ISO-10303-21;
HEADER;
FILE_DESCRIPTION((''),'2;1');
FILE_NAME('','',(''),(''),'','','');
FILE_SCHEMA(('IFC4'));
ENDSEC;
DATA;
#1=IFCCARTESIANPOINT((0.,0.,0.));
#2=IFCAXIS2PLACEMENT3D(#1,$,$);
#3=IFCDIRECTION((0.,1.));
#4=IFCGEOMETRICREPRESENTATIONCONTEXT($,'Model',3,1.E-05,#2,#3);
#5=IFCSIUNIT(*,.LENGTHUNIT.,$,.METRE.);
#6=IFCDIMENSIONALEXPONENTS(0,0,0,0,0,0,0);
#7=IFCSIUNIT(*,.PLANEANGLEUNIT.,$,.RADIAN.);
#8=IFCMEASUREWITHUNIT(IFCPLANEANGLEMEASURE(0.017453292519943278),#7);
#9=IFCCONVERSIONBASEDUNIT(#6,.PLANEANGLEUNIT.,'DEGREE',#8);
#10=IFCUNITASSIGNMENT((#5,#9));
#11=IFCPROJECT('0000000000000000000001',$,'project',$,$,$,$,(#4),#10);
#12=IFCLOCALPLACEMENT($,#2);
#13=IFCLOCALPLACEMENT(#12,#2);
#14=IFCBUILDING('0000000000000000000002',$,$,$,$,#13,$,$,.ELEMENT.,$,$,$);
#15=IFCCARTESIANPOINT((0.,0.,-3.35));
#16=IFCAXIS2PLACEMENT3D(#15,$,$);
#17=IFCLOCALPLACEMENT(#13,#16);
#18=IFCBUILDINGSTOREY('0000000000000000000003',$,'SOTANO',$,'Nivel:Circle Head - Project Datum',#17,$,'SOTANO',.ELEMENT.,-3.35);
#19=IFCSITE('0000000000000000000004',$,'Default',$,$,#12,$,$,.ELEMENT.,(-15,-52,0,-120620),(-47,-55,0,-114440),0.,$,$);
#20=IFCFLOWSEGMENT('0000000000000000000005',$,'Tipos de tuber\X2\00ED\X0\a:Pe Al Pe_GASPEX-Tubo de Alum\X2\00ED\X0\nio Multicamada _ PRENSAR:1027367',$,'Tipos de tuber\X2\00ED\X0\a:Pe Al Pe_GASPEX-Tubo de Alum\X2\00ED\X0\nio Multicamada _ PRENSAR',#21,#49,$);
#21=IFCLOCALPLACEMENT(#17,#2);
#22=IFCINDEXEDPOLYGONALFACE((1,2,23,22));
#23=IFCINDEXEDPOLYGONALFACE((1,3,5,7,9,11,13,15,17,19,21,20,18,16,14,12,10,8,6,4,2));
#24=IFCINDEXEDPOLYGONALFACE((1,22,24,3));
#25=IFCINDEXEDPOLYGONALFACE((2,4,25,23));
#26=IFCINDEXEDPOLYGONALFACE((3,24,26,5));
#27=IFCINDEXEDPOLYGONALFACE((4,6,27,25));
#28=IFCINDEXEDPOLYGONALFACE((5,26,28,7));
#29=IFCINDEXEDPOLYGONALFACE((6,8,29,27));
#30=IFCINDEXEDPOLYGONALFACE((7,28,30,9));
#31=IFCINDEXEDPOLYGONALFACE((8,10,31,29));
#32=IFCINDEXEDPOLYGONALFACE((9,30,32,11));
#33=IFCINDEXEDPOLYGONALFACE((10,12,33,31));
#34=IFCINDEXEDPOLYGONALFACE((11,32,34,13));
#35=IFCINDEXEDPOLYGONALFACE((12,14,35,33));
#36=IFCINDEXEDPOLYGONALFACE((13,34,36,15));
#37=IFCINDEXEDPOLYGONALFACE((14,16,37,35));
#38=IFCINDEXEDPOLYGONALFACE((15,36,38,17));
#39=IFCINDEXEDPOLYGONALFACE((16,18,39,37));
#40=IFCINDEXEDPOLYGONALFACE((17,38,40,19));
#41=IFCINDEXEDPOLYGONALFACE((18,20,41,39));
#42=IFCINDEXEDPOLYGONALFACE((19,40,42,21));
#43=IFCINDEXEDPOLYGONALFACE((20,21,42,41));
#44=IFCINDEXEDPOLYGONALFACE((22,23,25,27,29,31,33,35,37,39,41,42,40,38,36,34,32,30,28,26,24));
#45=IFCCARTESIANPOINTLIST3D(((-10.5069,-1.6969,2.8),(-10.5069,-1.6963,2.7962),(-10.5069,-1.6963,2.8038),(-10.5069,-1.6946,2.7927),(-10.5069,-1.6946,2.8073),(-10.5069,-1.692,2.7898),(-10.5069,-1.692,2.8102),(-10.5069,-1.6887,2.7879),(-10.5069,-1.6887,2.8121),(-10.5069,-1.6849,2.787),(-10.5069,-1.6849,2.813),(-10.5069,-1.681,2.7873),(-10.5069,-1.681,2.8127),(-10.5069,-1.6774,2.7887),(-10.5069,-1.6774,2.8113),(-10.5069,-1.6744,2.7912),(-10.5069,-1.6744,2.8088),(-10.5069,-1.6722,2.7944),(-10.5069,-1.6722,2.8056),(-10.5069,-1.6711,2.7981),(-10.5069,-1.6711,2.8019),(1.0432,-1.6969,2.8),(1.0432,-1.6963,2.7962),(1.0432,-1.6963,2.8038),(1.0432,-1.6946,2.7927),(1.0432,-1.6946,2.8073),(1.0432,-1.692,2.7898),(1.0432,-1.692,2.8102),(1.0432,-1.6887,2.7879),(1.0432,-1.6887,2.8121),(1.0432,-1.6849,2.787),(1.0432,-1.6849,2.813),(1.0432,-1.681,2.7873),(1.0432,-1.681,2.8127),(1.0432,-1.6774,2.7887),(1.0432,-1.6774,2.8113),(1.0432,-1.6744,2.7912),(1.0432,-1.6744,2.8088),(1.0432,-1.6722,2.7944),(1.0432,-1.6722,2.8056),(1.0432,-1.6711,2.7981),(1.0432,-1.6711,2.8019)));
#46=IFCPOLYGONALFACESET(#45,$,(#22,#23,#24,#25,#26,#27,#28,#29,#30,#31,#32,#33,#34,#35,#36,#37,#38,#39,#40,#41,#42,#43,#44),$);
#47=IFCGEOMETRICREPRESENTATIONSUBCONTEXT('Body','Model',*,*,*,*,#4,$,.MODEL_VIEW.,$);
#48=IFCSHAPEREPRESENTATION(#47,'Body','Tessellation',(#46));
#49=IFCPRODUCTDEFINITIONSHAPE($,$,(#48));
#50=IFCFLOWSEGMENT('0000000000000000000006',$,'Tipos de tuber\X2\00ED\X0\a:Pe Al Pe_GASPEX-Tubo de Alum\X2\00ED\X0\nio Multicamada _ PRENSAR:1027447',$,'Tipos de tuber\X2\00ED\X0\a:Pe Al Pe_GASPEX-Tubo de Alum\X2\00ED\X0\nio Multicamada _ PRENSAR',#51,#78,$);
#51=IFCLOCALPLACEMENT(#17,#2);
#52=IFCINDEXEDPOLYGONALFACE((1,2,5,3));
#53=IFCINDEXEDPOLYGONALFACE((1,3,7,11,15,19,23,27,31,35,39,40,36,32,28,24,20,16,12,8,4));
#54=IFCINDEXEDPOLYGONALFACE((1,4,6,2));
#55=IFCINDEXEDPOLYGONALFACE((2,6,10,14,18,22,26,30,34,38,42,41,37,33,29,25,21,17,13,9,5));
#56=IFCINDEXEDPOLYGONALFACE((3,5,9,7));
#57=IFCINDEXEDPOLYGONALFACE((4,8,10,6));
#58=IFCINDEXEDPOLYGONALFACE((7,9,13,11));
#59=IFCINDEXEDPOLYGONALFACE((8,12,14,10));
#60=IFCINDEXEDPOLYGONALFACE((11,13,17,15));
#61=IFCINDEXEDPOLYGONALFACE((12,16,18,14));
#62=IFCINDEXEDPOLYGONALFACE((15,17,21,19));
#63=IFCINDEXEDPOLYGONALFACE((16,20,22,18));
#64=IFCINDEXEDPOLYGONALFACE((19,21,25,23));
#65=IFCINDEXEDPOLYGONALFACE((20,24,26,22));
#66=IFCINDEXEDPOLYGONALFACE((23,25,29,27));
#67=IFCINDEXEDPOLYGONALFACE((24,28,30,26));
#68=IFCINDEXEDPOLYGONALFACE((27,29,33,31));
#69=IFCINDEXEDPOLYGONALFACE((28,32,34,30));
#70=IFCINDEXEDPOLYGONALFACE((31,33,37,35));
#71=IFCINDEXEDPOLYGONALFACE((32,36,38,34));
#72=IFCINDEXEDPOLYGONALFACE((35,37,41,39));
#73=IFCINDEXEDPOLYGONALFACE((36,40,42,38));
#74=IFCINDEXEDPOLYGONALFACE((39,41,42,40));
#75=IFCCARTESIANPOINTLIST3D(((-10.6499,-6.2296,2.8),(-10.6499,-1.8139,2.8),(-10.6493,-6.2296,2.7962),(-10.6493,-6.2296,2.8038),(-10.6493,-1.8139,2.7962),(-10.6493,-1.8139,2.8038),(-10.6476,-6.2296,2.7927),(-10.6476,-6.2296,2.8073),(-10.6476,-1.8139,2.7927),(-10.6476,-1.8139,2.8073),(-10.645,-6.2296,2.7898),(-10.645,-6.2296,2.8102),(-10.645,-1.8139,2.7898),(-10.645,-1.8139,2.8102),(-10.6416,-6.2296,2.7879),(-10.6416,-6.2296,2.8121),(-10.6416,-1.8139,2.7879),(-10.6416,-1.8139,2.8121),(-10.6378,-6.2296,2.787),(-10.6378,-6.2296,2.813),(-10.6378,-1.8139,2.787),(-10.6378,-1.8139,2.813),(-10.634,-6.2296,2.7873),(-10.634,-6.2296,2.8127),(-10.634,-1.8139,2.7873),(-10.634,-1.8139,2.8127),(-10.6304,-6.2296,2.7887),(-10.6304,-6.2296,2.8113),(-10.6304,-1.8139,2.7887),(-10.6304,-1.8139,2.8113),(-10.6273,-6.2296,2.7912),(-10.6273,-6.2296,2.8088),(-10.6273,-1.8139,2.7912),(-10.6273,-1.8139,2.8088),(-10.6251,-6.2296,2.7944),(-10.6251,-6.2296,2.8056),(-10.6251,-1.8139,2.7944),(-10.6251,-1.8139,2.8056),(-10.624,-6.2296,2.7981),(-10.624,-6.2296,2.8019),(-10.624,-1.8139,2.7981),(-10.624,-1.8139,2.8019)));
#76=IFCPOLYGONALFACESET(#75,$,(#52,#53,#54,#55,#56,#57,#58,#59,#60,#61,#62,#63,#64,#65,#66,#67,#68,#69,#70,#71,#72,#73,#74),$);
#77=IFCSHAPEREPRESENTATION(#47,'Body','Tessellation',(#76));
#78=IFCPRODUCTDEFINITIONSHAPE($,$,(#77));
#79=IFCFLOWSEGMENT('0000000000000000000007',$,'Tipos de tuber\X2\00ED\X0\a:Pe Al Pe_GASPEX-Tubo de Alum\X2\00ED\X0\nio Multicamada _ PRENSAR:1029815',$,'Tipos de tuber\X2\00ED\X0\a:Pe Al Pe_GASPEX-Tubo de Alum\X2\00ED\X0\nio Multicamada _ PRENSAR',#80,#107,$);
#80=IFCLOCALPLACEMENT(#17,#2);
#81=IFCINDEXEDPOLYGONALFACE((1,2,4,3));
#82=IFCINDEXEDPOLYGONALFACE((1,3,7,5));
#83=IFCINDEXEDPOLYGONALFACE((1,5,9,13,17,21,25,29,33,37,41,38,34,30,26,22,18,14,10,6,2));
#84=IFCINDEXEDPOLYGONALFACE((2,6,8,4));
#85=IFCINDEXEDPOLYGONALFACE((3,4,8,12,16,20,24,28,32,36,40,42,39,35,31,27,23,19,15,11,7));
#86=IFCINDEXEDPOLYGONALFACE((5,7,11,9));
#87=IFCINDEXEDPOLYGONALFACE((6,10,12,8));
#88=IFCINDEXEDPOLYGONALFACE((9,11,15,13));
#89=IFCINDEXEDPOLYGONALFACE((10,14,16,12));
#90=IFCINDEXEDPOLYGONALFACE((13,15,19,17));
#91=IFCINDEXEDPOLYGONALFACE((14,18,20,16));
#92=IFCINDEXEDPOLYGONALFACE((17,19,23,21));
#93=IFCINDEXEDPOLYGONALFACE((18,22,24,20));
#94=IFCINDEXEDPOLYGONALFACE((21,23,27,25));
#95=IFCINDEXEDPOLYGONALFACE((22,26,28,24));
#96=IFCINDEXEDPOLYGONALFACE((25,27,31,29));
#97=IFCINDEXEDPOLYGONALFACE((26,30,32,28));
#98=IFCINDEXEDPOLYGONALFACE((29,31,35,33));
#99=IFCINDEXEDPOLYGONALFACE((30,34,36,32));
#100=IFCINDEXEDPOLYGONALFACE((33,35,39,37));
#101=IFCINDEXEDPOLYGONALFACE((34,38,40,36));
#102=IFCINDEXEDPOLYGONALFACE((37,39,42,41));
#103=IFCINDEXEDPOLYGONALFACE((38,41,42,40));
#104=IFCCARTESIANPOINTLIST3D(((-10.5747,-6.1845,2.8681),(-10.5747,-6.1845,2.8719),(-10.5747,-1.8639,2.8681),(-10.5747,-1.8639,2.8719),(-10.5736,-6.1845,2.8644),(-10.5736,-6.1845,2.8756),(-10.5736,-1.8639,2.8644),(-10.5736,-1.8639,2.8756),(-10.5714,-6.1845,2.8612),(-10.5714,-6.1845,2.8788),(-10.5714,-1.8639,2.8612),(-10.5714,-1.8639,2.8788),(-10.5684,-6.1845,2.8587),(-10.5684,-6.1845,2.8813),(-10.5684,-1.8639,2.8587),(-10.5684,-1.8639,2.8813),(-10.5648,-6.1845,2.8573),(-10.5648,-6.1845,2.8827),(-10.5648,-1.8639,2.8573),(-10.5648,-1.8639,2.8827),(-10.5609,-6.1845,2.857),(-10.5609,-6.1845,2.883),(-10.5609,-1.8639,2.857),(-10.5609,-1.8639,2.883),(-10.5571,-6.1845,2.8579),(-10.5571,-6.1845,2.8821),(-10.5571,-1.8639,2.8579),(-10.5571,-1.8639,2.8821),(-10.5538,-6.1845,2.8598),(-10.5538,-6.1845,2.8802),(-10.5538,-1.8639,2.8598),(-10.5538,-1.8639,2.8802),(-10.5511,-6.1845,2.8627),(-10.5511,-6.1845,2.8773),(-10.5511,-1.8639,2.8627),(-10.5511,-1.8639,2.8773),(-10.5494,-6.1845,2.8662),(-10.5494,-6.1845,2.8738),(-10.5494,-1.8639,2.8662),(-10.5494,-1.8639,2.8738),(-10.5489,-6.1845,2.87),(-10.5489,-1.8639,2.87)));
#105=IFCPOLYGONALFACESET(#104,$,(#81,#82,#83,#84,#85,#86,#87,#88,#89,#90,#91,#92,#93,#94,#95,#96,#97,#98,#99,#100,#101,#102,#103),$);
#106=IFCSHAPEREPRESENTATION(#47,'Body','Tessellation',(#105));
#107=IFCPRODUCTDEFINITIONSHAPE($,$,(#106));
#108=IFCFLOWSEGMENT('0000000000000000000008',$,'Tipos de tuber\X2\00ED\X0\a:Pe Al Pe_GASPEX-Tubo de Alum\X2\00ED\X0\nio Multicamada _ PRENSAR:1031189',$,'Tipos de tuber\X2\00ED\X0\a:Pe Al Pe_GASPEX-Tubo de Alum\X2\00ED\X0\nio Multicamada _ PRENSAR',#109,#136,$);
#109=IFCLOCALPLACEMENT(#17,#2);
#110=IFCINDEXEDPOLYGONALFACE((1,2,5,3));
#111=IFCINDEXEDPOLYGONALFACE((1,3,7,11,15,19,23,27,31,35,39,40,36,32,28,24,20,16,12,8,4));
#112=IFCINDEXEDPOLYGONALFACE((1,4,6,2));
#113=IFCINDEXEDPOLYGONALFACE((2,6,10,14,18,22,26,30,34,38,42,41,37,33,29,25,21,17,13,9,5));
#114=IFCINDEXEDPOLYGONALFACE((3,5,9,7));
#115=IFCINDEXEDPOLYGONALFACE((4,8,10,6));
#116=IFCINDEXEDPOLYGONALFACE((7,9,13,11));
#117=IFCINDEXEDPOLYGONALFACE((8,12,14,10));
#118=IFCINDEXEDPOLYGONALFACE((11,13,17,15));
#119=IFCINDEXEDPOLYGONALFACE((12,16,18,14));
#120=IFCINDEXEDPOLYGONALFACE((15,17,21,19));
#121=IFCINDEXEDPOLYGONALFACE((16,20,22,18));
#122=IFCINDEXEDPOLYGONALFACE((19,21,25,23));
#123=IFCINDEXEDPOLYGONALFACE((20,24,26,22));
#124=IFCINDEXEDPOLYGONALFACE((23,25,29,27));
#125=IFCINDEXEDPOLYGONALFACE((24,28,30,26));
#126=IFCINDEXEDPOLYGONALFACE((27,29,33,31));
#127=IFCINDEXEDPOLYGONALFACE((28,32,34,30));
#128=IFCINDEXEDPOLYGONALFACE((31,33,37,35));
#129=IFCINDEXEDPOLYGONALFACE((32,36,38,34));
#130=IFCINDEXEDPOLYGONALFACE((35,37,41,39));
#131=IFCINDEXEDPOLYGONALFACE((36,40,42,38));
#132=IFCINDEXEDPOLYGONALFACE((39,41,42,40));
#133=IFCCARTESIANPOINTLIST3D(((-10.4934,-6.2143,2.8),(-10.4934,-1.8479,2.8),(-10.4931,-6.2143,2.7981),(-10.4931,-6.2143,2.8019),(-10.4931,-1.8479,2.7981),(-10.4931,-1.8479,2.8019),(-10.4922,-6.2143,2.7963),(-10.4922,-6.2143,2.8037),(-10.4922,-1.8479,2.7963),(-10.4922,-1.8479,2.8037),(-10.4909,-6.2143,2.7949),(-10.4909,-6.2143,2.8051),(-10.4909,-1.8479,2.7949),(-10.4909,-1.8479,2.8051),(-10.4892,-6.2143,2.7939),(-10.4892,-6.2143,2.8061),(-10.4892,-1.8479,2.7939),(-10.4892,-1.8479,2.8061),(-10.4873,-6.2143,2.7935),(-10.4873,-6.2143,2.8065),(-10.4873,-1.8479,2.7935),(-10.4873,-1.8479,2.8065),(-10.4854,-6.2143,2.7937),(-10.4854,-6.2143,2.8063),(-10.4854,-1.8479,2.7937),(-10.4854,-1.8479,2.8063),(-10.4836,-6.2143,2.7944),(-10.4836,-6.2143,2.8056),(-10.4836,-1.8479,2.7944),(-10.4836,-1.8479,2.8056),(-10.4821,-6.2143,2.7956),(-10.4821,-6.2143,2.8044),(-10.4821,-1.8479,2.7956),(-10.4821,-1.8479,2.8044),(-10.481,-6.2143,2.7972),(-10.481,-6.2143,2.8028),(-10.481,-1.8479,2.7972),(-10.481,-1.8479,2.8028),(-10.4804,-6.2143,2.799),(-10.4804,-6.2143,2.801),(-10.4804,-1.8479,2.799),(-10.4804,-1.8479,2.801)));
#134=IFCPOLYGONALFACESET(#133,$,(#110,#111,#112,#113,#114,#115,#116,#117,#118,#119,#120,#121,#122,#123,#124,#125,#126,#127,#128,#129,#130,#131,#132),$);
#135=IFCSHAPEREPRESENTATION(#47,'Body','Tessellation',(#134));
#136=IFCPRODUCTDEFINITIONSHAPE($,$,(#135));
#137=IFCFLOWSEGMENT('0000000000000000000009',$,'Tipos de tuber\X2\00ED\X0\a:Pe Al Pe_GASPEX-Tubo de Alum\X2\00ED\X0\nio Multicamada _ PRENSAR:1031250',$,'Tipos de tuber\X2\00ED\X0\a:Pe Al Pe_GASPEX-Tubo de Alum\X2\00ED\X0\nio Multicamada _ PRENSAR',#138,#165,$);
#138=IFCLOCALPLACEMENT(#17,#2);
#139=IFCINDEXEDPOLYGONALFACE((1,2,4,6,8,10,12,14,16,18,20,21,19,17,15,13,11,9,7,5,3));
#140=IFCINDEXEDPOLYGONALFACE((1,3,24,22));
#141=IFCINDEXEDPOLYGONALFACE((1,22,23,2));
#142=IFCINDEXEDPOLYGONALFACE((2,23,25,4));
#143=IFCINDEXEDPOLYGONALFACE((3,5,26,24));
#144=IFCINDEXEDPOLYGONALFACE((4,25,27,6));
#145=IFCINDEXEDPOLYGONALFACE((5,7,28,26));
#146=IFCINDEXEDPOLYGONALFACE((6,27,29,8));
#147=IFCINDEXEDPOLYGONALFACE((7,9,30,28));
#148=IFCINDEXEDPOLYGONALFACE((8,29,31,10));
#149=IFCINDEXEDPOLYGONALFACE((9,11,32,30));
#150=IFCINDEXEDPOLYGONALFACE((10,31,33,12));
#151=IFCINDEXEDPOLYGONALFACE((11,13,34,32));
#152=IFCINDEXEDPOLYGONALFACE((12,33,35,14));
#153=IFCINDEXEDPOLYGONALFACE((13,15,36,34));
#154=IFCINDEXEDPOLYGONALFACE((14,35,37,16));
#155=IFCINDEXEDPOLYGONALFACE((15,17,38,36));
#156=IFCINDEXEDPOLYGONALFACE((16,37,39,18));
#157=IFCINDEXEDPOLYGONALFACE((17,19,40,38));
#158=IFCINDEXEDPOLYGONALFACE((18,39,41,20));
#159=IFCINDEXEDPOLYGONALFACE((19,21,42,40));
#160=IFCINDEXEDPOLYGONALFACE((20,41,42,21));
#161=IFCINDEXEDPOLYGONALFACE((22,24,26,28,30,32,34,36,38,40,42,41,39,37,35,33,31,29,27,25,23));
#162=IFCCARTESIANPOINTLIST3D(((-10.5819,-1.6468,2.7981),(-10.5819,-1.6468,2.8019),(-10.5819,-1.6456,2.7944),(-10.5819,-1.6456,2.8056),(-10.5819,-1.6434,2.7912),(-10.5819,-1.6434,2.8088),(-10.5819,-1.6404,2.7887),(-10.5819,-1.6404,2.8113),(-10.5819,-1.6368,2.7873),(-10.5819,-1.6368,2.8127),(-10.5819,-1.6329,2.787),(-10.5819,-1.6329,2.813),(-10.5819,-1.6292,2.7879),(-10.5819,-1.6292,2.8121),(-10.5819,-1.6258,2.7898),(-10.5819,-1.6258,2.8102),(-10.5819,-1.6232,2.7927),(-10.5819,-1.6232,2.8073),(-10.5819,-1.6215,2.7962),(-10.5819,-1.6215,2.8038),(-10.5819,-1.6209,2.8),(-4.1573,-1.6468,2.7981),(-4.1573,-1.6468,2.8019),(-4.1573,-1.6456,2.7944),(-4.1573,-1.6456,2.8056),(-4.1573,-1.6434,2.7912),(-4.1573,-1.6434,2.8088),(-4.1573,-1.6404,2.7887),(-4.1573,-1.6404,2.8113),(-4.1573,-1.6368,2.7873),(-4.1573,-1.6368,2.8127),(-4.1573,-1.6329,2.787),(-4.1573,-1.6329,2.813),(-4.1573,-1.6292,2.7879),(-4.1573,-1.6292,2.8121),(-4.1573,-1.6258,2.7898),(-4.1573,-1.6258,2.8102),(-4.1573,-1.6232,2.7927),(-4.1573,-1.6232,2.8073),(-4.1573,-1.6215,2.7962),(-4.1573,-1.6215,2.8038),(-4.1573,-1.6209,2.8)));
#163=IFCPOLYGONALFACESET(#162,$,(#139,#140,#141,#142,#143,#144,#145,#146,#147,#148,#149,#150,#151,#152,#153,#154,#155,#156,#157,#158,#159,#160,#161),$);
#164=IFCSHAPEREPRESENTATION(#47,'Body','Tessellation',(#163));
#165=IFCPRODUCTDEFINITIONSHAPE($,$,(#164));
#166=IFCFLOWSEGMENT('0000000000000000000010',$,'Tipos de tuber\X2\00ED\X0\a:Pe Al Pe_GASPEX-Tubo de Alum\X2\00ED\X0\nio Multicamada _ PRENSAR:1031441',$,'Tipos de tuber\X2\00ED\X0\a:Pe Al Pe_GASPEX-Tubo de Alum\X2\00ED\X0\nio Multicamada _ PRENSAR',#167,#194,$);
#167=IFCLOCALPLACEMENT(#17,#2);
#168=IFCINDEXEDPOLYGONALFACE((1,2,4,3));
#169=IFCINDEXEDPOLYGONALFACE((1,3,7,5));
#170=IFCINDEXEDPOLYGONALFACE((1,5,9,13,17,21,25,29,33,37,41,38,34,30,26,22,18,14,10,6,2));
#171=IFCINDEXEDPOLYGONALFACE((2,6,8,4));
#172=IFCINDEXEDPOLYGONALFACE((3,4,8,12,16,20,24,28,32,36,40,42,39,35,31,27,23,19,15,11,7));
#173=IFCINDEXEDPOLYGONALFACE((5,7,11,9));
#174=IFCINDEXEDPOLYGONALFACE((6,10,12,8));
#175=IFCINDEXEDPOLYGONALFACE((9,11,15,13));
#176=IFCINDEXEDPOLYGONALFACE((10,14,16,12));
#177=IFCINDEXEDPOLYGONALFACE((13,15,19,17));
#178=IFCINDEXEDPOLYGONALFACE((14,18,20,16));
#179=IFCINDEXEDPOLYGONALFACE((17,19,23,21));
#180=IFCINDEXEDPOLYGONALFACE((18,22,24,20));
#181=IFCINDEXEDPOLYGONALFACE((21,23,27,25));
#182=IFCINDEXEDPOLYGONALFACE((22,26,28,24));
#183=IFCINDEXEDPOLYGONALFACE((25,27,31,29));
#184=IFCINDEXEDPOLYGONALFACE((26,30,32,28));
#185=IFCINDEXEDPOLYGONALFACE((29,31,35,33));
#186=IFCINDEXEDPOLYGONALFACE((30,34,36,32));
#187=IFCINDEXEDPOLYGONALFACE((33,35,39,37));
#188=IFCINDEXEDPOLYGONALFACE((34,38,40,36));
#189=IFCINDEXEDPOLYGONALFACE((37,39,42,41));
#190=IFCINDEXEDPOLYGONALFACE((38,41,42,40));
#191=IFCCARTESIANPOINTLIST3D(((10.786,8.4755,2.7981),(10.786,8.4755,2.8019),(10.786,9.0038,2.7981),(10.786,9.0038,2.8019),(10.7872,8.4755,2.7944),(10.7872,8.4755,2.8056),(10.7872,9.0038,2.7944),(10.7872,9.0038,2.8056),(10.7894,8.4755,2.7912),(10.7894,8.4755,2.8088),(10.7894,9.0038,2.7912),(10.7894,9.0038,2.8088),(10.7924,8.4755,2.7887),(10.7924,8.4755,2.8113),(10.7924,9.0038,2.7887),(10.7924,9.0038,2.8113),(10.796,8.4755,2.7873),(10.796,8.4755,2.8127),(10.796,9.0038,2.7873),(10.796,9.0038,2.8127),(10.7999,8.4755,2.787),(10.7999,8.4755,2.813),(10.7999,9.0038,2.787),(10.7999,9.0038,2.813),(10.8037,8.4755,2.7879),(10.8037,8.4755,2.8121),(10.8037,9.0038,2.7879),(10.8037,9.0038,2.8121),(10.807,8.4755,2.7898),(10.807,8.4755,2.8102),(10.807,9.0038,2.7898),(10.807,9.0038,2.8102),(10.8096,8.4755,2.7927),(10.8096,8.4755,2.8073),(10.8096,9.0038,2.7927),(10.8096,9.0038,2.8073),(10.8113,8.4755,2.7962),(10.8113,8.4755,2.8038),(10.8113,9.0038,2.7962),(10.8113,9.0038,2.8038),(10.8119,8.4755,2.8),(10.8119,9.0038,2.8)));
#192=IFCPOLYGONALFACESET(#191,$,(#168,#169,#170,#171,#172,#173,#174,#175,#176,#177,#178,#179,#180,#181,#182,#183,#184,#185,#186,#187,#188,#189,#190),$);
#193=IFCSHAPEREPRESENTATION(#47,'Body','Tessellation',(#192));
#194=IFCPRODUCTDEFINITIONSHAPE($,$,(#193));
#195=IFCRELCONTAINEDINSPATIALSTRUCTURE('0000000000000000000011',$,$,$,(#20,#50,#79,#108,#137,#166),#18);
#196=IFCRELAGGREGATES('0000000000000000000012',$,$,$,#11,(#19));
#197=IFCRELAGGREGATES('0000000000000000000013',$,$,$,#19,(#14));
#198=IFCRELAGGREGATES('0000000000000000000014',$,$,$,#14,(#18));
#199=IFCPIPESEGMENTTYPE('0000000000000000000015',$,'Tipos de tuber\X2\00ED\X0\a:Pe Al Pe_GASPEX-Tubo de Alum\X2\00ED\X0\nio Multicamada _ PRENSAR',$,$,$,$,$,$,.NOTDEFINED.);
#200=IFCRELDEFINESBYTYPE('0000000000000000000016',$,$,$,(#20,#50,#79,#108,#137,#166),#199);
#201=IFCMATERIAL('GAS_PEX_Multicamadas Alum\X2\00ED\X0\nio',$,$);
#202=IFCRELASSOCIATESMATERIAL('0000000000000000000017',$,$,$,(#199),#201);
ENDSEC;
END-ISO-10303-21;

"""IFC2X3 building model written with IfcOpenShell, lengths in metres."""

from ifc_helpers import new_model, entity, si_unit, converted_unit, direction, frame, frame_2d, origin, origin_2d_with_axis, place, context, subcontext, project, spatial, circle, extrude, material, type_object, element, save


model = new_model("IFC2X3")

# Units and contexts
model_context = context("Model", 3, precision=1e-05, world=origin(), true_north=direction((0.0, 1.0)))
body_context = subcontext(model_context, "Body", "Model", "MODEL_VIEW")
ifc_project = project(units=[si_unit("LENGTHUNIT", "METRE"), converted_unit("PLANEANGLEUNIT", "DEGREE", entity("IfcPlaneAngleMeasure", 0.017453292519943278), si_unit("PLANEANGLEUNIT", "RADIAN"), dimensions=[0, 0, 0, 0, 0, 0, 0])], contexts=[model_context])

# Site, building, storey
site_placement = place(None, origin())
site = spatial("IfcSite", under=ifc_project, at=site_placement, Name="Default", CompositionType="ELEMENT", RefLatitude=(-15, -52, 0, -120620), RefLongitude=(-47, -55, 0, -114440), RefElevation=0.0)
building_placement = place(site_placement, origin())
building = spatial("IfcBuilding", under=site, at=building_placement, CompositionType="ELEMENT")
storey_placement = place(building_placement, frame((0.0, 0.0, -3.35)))
storey = spatial("IfcBuildingStorey", under=building, at=storey_placement, Name="SOTANO", ObjectType="Nivel:Circle Head - Project Datum", LongName="SOTANO", CompositionType="ELEMENT", Elevation=-3.35)

# Flow segments
ifc_material = material(Name="GAS_PEX_Multicamadas Alumínio")
pipe_segment_type_1 = type_object("IfcPipeSegmentType", Name="Tipos de tubería:Pe Al Pe_GASPEX-Tubo de Alumínio Multicamada _ PRENSAR", PredefinedType="NOTDEFINED", material=ifc_material)
flow_segment_1_placement = place(storey_placement, origin())
element("IfcFlowSegment", 1, at=flow_segment_1_placement, inside=storey, type_object=pipe_segment_type_1, Name="Tipos de tubería:Pe Al Pe_GASPEX-Tubo de Alumínio Multicamada _ PRENSAR:1027367", ObjectType="Tipos de tubería:Pe Al Pe_GASPEX-Tubo de Alumínio Multicamada _ PRENSAR", context=body_context, shape_type="SweptSolid", body=[
    extrude(circle(Radius=0.013, at=origin_2d_with_axis()), frame((-10.5069, -1.6839, 2.8), z_axis=(1.0, 0.0, 0.0), x_axis=(0.0, -1.0, 0.0)), (0.0, 0.0, 1.0), 11.5501),
])
flow_segment_2_placement = place(storey_placement, origin())
element("IfcFlowSegment", 2, at=flow_segment_2_placement, inside=storey, type_object=pipe_segment_type_1, Name="Tipos de tubería:Pe Al Pe_GASPEX-Tubo de Alumínio Multicamada _ PRENSAR:1027447", ObjectType="Tipos de tubería:Pe Al Pe_GASPEX-Tubo de Alumínio Multicamada _ PRENSAR", context=body_context, shape_type="SweptSolid", body=[
    extrude(circle(Radius=0.013, at=frame_2d((0.0, 0.0), x_axis=(1.0, 0.0))), frame((-10.6369, -6.2296, 2.8), z_axis=(0.0, 1.0, 0.0), x_axis=(-1.0, 0.0, 0.0)), (0.0, 0.0, 1.0), 4.4157),
])
flow_segment_3_placement = place(storey_placement, origin())
element("IfcFlowSegment", 3, at=flow_segment_3_placement, inside=storey, type_object=pipe_segment_type_1, Name="Tipos de tubería:Pe Al Pe_GASPEX-Tubo de Alumínio Multicamada _ PRENSAR:1029815", ObjectType="Tipos de tubería:Pe Al Pe_GASPEX-Tubo de Alumínio Multicamada _ PRENSAR", context=body_context, shape_type="SweptSolid", body=[
    extrude(circle(Radius=0.013, at=origin_2d_with_axis()), frame((-10.5619, -6.1845, 2.87), z_axis=(0.0, 1.0, 0.0), x_axis=(1.0, 0.0, 0.0)), (0.0, 0.0, 1.0), 4.3206),
])
flow_segment_4_placement = place(storey_placement, origin())
element("IfcFlowSegment", 4, at=flow_segment_4_placement, inside=storey, type_object=pipe_segment_type_1, Name="Tipos de tubería:Pe Al Pe_GASPEX-Tubo de Alumínio Multicamada _ PRENSAR:1031189", ObjectType="Tipos de tubería:Pe Al Pe_GASPEX-Tubo de Alumínio Multicamada _ PRENSAR", context=body_context, shape_type="SweptSolid", body=[
    extrude(circle(Radius=0.0065, at=frame_2d((0.0, 0.0), x_axis=(1.0, 0.0))), frame((-10.4869, -6.2143, 2.8), z_axis=(0.0, 1.0, 0.0), x_axis=(-1.0, 0.0, 0.0)), (0.0, 0.0, 1.0), 4.3665),
])
flow_segment_5_placement = place(storey_placement, origin())
element("IfcFlowSegment", 5, at=flow_segment_5_placement, inside=storey, type_object=pipe_segment_type_1, Name="Tipos de tubería:Pe Al Pe_GASPEX-Tubo de Alumínio Multicamada _ PRENSAR:1031250", ObjectType="Tipos de tubería:Pe Al Pe_GASPEX-Tubo de Alumínio Multicamada _ PRENSAR", context=body_context, shape_type="SweptSolid", body=[
    extrude(circle(Radius=0.013, at=frame_2d((0.0, 0.0), x_axis=(1.0, 0.0))), frame((-10.5819, -1.6339, 2.8), z_axis=(1.0, 0.0, 0.0), x_axis=(0.0, 1.0, 0.0)), (0.0, 0.0, 1.0), 6.4245),
])
flow_segment_6_placement = place(storey_placement, origin())
element("IfcFlowSegment", 6, at=flow_segment_6_placement, inside=storey, type_object=pipe_segment_type_1, Name="Tipos de tubería:Pe Al Pe_GASPEX-Tubo de Alumínio Multicamada _ PRENSAR:1031441", ObjectType="Tipos de tubería:Pe Al Pe_GASPEX-Tubo de Alumínio Multicamada _ PRENSAR", context=body_context, shape_type="SweptSolid", body=[
    extrude(circle(Radius=0.013, at=origin_2d_with_axis()), frame((10.7989, 8.4755, 2.8), z_axis=(0.0, 1.0, 0.0), x_axis=(1.0, 0.0, 0.0)), (0.0, 0.0, 1.0), 0.5283),
])

save(model, "model.ifc")
